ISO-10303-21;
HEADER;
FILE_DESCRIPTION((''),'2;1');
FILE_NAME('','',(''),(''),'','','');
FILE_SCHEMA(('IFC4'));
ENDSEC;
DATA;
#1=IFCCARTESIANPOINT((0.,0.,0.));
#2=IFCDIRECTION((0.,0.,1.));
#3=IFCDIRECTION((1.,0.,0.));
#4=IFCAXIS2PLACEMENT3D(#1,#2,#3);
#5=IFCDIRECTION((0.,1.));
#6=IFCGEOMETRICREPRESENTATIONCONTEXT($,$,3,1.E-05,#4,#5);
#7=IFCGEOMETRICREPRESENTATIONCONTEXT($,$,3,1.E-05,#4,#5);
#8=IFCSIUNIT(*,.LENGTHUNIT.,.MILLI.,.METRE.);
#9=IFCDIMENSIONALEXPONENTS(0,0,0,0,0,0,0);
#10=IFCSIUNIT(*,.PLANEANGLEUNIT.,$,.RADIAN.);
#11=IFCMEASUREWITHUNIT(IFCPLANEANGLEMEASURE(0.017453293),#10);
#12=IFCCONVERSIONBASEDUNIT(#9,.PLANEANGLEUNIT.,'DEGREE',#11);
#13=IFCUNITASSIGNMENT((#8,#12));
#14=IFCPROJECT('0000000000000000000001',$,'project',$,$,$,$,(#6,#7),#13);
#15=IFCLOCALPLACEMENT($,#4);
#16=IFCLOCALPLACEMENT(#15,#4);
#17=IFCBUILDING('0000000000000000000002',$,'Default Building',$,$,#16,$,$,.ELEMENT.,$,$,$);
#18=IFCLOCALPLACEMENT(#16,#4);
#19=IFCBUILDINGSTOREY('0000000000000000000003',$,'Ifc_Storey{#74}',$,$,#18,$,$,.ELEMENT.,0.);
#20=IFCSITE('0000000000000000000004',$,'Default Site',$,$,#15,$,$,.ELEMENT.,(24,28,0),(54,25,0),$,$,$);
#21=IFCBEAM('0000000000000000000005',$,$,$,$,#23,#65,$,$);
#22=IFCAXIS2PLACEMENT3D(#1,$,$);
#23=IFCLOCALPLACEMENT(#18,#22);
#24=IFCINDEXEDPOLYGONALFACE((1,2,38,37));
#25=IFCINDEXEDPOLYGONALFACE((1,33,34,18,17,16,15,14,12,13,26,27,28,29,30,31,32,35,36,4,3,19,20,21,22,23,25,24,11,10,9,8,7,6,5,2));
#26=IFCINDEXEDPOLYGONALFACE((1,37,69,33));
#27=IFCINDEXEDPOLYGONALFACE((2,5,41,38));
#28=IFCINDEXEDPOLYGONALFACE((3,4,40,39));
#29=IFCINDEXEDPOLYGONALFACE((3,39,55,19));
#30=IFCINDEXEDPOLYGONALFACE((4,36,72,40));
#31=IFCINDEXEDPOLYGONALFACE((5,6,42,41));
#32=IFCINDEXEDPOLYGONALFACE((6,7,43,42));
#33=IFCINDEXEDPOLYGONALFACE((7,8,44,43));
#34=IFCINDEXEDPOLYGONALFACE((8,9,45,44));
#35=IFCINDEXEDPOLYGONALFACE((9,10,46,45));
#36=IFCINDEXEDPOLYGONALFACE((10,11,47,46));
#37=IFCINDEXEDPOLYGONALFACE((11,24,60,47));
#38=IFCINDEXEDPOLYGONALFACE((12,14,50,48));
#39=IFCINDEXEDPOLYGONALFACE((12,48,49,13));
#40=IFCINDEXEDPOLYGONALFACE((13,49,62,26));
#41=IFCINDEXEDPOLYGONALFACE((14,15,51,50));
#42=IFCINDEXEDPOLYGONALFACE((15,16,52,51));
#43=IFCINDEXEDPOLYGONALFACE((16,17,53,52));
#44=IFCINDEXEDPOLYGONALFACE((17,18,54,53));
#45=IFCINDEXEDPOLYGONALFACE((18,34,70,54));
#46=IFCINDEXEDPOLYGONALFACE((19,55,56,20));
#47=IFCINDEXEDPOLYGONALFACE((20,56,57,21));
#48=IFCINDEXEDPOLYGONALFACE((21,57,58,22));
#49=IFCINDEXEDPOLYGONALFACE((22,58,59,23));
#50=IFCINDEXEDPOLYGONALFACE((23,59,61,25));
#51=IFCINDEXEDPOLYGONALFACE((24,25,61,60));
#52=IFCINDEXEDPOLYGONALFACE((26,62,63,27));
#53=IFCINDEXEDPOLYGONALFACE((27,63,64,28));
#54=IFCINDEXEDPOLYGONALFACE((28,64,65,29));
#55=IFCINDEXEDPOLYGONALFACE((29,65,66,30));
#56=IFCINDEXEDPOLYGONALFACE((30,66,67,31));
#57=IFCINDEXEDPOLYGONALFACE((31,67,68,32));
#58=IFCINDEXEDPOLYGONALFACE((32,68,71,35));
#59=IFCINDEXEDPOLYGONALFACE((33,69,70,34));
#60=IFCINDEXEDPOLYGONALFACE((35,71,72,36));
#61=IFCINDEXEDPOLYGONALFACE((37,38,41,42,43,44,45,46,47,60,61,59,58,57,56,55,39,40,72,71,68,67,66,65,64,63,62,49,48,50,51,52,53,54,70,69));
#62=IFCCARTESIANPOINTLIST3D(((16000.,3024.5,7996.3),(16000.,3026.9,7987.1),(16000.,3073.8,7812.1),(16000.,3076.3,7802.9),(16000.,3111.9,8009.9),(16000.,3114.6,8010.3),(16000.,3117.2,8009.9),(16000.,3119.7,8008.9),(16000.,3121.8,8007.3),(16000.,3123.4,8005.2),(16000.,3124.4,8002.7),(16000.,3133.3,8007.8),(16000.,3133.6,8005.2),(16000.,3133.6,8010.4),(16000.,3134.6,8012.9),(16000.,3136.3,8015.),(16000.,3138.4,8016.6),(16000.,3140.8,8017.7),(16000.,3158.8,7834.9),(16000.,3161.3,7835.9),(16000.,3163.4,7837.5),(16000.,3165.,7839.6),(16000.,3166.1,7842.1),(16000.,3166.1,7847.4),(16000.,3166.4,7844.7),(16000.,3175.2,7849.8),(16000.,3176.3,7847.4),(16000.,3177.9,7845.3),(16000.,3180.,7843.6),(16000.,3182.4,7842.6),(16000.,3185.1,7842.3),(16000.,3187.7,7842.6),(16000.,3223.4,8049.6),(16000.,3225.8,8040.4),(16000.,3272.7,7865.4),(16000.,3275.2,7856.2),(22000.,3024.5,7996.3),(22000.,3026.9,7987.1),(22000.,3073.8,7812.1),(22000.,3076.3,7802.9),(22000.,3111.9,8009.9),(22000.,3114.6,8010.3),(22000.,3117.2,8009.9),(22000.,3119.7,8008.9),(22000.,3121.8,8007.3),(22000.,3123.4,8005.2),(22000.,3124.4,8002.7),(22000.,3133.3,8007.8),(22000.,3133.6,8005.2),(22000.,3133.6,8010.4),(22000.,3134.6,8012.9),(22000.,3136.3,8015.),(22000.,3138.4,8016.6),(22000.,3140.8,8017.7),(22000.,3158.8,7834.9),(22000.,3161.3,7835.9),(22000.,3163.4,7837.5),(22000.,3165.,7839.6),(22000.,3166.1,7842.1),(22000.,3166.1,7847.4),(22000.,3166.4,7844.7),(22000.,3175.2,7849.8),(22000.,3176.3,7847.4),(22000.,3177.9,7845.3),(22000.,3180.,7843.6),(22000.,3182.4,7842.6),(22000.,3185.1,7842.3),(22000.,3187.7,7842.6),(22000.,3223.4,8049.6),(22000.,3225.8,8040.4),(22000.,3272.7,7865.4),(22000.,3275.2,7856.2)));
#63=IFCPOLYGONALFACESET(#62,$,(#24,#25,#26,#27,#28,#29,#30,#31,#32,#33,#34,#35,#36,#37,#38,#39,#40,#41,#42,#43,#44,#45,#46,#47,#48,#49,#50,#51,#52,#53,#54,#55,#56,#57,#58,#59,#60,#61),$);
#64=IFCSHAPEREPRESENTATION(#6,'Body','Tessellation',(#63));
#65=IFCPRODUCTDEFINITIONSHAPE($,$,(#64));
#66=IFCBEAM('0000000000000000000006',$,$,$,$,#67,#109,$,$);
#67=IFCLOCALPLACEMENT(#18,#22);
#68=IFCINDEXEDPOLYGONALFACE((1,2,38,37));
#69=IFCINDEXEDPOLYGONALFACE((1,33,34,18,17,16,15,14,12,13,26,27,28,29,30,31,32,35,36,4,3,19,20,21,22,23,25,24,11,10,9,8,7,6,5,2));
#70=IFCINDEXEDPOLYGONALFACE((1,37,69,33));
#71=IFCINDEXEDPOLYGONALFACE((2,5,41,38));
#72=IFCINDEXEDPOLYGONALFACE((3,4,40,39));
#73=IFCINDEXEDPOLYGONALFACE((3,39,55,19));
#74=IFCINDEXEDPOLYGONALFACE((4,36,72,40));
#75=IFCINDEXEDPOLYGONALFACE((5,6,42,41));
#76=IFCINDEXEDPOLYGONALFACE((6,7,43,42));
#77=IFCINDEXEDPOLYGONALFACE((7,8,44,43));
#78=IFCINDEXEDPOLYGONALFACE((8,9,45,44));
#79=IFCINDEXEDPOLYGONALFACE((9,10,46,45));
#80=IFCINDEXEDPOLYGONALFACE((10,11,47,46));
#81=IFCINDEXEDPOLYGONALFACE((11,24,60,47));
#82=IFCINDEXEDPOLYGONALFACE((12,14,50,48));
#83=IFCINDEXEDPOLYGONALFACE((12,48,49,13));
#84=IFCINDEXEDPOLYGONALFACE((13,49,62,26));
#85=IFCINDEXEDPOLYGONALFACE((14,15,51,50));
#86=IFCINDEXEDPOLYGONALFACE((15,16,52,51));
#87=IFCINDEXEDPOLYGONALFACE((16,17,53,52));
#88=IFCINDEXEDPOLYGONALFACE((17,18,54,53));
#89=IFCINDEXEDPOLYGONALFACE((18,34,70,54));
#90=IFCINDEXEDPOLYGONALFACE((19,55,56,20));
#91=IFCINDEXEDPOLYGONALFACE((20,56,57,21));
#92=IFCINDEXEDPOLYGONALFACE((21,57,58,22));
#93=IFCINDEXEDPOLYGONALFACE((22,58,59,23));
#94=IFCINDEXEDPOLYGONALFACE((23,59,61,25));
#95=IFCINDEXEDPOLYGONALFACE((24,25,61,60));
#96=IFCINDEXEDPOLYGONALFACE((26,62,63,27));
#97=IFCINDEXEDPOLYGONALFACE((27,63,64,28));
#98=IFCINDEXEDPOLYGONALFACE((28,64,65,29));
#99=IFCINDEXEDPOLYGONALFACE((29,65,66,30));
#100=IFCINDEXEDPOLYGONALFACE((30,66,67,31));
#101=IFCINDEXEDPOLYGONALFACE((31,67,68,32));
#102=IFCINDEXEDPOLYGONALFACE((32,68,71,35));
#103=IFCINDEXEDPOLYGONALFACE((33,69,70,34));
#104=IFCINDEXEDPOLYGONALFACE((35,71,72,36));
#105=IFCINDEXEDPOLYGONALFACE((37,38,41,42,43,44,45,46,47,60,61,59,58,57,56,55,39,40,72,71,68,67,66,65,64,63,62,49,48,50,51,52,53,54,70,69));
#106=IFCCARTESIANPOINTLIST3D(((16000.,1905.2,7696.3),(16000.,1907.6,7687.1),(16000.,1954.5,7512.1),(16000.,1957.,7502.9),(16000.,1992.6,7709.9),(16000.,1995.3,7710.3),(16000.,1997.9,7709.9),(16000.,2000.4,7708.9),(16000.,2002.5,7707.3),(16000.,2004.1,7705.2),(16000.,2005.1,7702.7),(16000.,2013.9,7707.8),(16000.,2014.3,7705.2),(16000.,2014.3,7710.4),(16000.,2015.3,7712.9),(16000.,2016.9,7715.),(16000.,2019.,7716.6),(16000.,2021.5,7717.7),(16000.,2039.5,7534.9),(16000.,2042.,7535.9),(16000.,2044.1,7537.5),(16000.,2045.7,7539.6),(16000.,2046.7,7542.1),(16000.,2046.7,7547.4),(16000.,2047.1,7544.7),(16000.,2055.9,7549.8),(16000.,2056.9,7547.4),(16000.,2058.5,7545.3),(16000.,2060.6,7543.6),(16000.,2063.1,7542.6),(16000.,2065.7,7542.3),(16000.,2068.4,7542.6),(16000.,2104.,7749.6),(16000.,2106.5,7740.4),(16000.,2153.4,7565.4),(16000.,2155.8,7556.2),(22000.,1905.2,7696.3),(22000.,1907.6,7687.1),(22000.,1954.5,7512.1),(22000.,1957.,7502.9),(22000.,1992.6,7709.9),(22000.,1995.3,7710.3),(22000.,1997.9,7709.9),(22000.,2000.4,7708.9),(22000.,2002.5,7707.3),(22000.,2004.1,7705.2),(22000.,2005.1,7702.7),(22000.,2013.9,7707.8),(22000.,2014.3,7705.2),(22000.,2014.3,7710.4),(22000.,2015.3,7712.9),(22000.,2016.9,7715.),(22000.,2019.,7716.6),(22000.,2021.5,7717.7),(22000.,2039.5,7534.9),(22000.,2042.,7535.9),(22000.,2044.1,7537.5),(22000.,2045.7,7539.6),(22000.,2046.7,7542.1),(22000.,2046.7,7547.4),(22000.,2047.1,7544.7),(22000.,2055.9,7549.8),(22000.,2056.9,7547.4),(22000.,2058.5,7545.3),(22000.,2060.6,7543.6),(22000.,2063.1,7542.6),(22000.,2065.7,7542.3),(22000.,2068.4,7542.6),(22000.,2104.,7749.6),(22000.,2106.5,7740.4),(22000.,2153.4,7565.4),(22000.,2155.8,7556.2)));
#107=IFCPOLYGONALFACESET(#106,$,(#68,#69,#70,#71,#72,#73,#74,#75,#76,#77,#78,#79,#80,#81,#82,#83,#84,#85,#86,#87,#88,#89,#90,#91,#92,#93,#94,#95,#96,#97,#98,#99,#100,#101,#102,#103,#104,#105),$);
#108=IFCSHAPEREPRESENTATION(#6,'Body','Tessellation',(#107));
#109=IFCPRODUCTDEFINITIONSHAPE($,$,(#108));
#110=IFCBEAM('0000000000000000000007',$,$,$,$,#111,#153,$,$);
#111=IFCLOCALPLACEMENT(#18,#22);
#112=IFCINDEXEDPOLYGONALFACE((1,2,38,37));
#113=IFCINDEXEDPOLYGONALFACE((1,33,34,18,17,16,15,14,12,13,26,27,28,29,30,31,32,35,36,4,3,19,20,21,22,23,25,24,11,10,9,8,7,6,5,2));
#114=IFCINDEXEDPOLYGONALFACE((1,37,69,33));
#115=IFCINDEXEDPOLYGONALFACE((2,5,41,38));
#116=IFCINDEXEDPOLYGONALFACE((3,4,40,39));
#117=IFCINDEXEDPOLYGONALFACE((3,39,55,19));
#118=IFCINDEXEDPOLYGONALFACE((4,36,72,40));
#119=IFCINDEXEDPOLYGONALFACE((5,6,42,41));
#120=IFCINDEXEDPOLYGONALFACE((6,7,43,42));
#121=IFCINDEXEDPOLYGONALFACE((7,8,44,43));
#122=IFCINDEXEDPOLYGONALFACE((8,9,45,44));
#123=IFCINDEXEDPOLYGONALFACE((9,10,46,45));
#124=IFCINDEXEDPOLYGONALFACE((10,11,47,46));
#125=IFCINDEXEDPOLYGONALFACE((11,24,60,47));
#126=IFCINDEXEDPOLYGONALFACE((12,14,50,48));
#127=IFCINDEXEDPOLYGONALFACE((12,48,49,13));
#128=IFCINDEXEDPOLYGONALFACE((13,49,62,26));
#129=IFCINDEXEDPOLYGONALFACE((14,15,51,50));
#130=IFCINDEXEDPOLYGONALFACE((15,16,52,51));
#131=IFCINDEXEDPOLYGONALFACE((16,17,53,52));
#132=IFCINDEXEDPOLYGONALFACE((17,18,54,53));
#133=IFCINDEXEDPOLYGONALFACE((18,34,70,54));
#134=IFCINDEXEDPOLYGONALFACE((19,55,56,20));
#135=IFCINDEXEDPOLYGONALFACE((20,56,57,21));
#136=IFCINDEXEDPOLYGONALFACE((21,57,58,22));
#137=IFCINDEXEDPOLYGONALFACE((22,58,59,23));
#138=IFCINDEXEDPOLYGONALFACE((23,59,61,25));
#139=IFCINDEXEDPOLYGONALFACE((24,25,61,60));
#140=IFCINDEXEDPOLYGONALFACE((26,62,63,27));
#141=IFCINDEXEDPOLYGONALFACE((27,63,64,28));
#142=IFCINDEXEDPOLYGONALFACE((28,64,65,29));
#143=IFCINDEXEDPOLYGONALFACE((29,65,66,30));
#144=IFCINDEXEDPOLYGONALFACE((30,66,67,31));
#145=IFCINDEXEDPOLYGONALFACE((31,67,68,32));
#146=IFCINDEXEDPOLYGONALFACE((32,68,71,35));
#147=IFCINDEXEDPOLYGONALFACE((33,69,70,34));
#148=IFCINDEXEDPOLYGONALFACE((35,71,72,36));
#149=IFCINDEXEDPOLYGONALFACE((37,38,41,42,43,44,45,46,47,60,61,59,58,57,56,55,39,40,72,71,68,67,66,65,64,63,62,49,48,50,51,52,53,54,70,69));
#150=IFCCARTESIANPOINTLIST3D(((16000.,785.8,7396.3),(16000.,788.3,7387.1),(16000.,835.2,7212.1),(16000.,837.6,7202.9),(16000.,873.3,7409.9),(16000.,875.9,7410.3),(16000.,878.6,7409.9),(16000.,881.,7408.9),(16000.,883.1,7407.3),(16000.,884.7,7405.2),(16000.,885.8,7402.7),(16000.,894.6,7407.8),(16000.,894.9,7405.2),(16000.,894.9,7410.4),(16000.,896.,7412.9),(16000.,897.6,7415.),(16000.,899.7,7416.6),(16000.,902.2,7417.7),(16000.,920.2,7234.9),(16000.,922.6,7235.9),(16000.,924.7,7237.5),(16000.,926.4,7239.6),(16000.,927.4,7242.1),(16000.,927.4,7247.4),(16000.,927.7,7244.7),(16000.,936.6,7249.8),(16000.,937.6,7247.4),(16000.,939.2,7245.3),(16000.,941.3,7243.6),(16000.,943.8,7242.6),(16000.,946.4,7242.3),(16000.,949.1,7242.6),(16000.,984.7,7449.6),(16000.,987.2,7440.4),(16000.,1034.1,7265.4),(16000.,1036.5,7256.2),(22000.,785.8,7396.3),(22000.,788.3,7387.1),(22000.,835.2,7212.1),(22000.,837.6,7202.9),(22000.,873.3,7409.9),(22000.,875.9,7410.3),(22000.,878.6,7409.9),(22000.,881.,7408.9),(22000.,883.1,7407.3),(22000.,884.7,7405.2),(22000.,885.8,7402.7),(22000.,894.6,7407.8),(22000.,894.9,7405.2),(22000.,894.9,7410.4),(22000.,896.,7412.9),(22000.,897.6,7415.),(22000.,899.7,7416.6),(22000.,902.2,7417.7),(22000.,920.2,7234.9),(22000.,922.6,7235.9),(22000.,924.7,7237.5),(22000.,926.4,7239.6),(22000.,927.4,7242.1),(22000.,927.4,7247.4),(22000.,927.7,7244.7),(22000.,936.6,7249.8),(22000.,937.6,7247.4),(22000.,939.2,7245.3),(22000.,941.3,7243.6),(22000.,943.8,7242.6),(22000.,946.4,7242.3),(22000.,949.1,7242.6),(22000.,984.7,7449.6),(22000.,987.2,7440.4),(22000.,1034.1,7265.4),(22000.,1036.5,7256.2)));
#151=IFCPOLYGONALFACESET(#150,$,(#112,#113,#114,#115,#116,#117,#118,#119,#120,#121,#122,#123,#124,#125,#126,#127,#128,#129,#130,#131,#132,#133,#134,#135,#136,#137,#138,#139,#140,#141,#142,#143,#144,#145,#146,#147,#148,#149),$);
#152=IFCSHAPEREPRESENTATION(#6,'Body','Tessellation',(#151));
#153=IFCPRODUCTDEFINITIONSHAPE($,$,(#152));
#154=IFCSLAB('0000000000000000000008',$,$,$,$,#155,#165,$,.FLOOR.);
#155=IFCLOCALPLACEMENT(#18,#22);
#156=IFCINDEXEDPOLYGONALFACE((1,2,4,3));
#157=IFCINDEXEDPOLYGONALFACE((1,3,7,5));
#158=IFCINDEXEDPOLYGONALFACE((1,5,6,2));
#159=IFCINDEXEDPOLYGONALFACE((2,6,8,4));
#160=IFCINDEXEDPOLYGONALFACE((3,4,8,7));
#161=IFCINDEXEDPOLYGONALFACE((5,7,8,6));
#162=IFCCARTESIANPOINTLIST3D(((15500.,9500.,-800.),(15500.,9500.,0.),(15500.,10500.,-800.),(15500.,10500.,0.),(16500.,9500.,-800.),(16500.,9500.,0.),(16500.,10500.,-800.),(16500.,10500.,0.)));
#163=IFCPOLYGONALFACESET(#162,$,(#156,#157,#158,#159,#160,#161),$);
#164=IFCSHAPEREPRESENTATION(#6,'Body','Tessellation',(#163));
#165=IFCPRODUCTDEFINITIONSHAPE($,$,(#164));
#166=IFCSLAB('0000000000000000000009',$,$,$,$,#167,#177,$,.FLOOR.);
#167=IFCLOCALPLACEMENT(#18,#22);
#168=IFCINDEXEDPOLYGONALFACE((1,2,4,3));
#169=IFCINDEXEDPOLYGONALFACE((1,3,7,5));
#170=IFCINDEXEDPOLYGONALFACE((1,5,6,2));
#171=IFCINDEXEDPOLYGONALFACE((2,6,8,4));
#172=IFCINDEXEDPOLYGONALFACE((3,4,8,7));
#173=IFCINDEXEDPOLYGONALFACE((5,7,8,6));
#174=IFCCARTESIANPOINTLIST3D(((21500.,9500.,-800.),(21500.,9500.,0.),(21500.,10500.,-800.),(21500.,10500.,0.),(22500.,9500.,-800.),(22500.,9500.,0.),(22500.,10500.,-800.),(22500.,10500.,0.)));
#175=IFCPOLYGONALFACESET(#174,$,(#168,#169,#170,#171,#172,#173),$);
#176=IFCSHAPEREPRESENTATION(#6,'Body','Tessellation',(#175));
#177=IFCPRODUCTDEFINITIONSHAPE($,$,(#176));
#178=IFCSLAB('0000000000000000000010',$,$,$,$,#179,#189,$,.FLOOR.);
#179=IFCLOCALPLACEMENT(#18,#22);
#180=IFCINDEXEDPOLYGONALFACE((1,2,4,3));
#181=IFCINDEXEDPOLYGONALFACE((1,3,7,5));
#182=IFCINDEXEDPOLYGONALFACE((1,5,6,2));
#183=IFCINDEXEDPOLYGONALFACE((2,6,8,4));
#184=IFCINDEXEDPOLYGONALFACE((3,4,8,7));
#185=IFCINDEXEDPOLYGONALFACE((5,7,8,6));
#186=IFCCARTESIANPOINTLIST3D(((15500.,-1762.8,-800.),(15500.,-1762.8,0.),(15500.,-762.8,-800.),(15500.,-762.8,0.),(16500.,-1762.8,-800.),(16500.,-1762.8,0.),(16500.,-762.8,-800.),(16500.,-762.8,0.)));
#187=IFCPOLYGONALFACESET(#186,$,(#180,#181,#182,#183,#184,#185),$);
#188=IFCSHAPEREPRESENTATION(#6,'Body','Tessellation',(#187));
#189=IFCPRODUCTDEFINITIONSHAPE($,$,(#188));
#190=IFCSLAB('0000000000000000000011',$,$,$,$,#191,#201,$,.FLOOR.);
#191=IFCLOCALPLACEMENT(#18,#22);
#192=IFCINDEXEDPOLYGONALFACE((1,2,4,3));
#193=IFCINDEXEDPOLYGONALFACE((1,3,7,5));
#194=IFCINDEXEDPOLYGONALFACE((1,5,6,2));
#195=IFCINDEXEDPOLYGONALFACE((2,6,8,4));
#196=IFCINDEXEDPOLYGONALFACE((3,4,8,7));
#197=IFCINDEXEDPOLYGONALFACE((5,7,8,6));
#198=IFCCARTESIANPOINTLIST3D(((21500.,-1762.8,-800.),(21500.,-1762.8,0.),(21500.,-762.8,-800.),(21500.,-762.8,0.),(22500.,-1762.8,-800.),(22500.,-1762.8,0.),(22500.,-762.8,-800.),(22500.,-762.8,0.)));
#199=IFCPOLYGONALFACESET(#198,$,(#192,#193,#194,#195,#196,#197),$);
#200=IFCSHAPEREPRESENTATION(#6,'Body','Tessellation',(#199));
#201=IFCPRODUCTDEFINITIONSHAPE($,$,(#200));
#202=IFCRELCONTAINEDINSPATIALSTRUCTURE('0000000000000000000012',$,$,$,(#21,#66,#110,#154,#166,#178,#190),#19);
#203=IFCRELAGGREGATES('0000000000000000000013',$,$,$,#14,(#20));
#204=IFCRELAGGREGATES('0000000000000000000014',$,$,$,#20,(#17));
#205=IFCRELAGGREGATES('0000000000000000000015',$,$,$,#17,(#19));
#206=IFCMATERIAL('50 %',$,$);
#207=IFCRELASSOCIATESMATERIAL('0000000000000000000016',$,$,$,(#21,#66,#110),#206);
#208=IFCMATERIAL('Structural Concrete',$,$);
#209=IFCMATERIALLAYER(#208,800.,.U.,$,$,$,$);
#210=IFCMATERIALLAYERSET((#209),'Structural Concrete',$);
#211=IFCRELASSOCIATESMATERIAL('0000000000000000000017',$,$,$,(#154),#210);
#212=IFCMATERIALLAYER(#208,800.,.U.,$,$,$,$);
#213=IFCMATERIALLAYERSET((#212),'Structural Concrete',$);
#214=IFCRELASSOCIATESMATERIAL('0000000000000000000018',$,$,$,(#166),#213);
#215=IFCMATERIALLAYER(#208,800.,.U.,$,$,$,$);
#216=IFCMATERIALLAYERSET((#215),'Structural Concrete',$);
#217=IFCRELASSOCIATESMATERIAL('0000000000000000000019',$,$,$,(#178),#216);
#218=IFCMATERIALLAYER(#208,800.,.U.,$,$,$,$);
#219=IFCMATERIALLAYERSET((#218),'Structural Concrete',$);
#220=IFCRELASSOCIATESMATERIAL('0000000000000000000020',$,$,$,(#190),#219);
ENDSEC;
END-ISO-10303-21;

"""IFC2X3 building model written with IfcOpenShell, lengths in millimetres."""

from ifc_helpers import new_model, entity, si_unit, converted_unit, direction, frame, origin_with_axes, origin_2d_with_axis, place, context, project, spatial, polyline, i_section, outline, extrude, material, layer, layer_set, layer_usage, element, save


model = new_model("IFC2X3")

# Units and contexts
context_of_model_1 = context(None, 3, precision=1e-05, world=origin_with_axes(), true_north=direction((0.0, 1.0)))
context_of_model_2 = context(None, 3, precision=1e-05, world=origin_with_axes(), true_north=direction((0.0, 1.0)))
ifc_project = project(units=[si_unit("LENGTHUNIT", "METRE", prefix="MILLI"), converted_unit("PLANEANGLEUNIT", "DEGREE", entity("IfcPlaneAngleMeasure", 0.017453293), si_unit("PLANEANGLEUNIT", "RADIAN"), dimensions=[0, 0, 0, 0, 0, 0, 0])], contexts=[context_of_model_1, context_of_model_2])

# Site, building, storey
site_placement = place(None, origin_with_axes())
site = spatial("IfcSite", under=ifc_project, at=site_placement, Name="Default Site", CompositionType="ELEMENT", RefLatitude=(24, 28, 0), RefLongitude=(54, 25, 0))
building_placement = place(site_placement, origin_with_axes())
building = spatial("IfcBuilding", under=site, at=building_placement, Name="Default Building", CompositionType="ELEMENT")
storey_placement = place(building_placement, origin_with_axes())
storey = spatial("IfcBuildingStorey", under=building, at=storey_placement, Name="Ifc_Storey{#74}", CompositionType="ELEMENT", Elevation=0.0)

# Shared definitions
ifc_material_1 = material(Name="50 %")

# Beams
for number, where, z_axis, x_axis in (
    (1, (16000.0, 3149.8, 7926.3), (0.0, -0.258819, 0.965926), (-1.0, 0.0, 0.0)),
    (2, (16000.0, 2030.5, 7626.3), (0.0, -0.258819, 0.965926), (-1.0, 0.0, 0.0)),
    (3, (16000.0, 911.2, 7326.3), (0.0, -0.258819, 0.965926), (-1.0, 0.0, 0.0)),
):
    element("IfcBeam", number, at=place(storey_placement, frame(where, z_axis=z_axis, x_axis=x_axis)), inside=storey, material=ifc_material_1, context=context_of_model_1, shape_type="SweptSolid", body=[
        extrude(i_section(OverallWidth=205.9, OverallDepth=200.2, WebThickness=9.5, FlangeThickness=9.5, FilletRadius=10.2, at=origin_2d_with_axis()), frame((0.0, 0.0, 0.0), z_axis=(-1.0, 0.0, 0.0), x_axis=(0.0, 1.0, 0.0)), (0.0, 0.0, 1.0), 6000.0),
    ])

# Slabs
ifc_material_2 = material(Name="Structural Concrete")
ifc_layer_1 = layer(ifc_material_2, 800.0, ventilated="UNKNOWN")
ifc_layer_set_1 = layer_set([ifc_layer_1], Name="Structural Concrete")
ifc_layer_usage_1 = layer_usage(ifc_layer_set_1, "AXIS3", "NEGATIVE", 800.0)
slab_1_placement = place(storey_placement, frame((15500.0, 10500.0, -800.0), z_axis=(0.0, 0.0, 1.0), x_axis=(0.0, -1.0, 0.0)))
element("IfcSlab", 4, at=slab_1_placement, inside=storey, material=ifc_layer_usage_1, PredefinedType="FLOOR", context=context_of_model_1, shape_type="SweptSolid", body=[
    extrude(outline(polyline([(0.0, 0.0), (1000.0, 0.0), (1000.0, 1000.0), (0.0, 1000.0), (0.0, 0.0)])), origin_with_axes(), (0.0, 0.0, 1.0), 800.0),
])
ifc_layer_2 = layer(ifc_material_2, 800.0, ventilated="UNKNOWN")
ifc_layer_set_2 = layer_set([ifc_layer_2], Name="Structural Concrete")
ifc_layer_usage_2 = layer_usage(ifc_layer_set_2, "AXIS3", "NEGATIVE", 800.0)
slab_2_placement = place(storey_placement, frame((21500.0, 10500.0, -800.0), z_axis=(0.0, 0.0, 1.0), x_axis=(0.0, -1.0, 0.0)))
element("IfcSlab", 5, at=slab_2_placement, inside=storey, material=ifc_layer_usage_2, PredefinedType="FLOOR", context=context_of_model_1, shape_type="SweptSolid", body=[
    extrude(outline(polyline([(0.0, 0.0), (1000.0, 0.0), (1000.0, 1000.0), (0.0, 1000.0), (0.0, 0.0)])), origin_with_axes(), (0.0, 0.0, 1.0), 800.0),
])
ifc_layer_3 = layer(ifc_material_2, 800.0, ventilated="UNKNOWN")
ifc_layer_set_3 = layer_set([ifc_layer_3], Name="Structural Concrete")
ifc_layer_usage_3 = layer_usage(ifc_layer_set_3, "AXIS3", "NEGATIVE", 800.0)
slab_3_placement = place(storey_placement, frame((15500.0, -1762.8, -800.0), z_axis=(0.0, 0.0, 1.0), x_axis=(0.0, 1.0, 0.0)))
element("IfcSlab", 6, at=slab_3_placement, inside=storey, material=ifc_layer_usage_3, PredefinedType="FLOOR", context=context_of_model_1, shape_type="SweptSolid", body=[
    extrude(outline(polyline([(0.0, 0.0), (1000.0, 0.0), (1000.0, -1000.0), (0.0, -1000.0), (0.0, 0.0)])), origin_with_axes(), (0.0, 0.0, 1.0), 800.0),
])
ifc_layer_4 = layer(ifc_material_2, 800.0, ventilated="UNKNOWN")
ifc_layer_set_4 = layer_set([ifc_layer_4], Name="Structural Concrete")
ifc_layer_usage_4 = layer_usage(ifc_layer_set_4, "AXIS3", "NEGATIVE", 800.0)
slab_4_placement = place(storey_placement, frame((21500.0, -1762.8, -800.0), z_axis=(0.0, 0.0, 1.0), x_axis=(0.0, 1.0, 0.0)))
element("IfcSlab", 7, at=slab_4_placement, inside=storey, material=ifc_layer_usage_4, PredefinedType="FLOOR", context=context_of_model_1, shape_type="SweptSolid", body=[
    extrude(outline(polyline([(0.0, 0.0), (1000.0, 0.0), (1000.0, -1000.0), (0.0, -1000.0), (0.0, 0.0)])), origin_with_axes(), (0.0, 0.0, 1.0), 800.0),
])

save(model, "model.ifc")
